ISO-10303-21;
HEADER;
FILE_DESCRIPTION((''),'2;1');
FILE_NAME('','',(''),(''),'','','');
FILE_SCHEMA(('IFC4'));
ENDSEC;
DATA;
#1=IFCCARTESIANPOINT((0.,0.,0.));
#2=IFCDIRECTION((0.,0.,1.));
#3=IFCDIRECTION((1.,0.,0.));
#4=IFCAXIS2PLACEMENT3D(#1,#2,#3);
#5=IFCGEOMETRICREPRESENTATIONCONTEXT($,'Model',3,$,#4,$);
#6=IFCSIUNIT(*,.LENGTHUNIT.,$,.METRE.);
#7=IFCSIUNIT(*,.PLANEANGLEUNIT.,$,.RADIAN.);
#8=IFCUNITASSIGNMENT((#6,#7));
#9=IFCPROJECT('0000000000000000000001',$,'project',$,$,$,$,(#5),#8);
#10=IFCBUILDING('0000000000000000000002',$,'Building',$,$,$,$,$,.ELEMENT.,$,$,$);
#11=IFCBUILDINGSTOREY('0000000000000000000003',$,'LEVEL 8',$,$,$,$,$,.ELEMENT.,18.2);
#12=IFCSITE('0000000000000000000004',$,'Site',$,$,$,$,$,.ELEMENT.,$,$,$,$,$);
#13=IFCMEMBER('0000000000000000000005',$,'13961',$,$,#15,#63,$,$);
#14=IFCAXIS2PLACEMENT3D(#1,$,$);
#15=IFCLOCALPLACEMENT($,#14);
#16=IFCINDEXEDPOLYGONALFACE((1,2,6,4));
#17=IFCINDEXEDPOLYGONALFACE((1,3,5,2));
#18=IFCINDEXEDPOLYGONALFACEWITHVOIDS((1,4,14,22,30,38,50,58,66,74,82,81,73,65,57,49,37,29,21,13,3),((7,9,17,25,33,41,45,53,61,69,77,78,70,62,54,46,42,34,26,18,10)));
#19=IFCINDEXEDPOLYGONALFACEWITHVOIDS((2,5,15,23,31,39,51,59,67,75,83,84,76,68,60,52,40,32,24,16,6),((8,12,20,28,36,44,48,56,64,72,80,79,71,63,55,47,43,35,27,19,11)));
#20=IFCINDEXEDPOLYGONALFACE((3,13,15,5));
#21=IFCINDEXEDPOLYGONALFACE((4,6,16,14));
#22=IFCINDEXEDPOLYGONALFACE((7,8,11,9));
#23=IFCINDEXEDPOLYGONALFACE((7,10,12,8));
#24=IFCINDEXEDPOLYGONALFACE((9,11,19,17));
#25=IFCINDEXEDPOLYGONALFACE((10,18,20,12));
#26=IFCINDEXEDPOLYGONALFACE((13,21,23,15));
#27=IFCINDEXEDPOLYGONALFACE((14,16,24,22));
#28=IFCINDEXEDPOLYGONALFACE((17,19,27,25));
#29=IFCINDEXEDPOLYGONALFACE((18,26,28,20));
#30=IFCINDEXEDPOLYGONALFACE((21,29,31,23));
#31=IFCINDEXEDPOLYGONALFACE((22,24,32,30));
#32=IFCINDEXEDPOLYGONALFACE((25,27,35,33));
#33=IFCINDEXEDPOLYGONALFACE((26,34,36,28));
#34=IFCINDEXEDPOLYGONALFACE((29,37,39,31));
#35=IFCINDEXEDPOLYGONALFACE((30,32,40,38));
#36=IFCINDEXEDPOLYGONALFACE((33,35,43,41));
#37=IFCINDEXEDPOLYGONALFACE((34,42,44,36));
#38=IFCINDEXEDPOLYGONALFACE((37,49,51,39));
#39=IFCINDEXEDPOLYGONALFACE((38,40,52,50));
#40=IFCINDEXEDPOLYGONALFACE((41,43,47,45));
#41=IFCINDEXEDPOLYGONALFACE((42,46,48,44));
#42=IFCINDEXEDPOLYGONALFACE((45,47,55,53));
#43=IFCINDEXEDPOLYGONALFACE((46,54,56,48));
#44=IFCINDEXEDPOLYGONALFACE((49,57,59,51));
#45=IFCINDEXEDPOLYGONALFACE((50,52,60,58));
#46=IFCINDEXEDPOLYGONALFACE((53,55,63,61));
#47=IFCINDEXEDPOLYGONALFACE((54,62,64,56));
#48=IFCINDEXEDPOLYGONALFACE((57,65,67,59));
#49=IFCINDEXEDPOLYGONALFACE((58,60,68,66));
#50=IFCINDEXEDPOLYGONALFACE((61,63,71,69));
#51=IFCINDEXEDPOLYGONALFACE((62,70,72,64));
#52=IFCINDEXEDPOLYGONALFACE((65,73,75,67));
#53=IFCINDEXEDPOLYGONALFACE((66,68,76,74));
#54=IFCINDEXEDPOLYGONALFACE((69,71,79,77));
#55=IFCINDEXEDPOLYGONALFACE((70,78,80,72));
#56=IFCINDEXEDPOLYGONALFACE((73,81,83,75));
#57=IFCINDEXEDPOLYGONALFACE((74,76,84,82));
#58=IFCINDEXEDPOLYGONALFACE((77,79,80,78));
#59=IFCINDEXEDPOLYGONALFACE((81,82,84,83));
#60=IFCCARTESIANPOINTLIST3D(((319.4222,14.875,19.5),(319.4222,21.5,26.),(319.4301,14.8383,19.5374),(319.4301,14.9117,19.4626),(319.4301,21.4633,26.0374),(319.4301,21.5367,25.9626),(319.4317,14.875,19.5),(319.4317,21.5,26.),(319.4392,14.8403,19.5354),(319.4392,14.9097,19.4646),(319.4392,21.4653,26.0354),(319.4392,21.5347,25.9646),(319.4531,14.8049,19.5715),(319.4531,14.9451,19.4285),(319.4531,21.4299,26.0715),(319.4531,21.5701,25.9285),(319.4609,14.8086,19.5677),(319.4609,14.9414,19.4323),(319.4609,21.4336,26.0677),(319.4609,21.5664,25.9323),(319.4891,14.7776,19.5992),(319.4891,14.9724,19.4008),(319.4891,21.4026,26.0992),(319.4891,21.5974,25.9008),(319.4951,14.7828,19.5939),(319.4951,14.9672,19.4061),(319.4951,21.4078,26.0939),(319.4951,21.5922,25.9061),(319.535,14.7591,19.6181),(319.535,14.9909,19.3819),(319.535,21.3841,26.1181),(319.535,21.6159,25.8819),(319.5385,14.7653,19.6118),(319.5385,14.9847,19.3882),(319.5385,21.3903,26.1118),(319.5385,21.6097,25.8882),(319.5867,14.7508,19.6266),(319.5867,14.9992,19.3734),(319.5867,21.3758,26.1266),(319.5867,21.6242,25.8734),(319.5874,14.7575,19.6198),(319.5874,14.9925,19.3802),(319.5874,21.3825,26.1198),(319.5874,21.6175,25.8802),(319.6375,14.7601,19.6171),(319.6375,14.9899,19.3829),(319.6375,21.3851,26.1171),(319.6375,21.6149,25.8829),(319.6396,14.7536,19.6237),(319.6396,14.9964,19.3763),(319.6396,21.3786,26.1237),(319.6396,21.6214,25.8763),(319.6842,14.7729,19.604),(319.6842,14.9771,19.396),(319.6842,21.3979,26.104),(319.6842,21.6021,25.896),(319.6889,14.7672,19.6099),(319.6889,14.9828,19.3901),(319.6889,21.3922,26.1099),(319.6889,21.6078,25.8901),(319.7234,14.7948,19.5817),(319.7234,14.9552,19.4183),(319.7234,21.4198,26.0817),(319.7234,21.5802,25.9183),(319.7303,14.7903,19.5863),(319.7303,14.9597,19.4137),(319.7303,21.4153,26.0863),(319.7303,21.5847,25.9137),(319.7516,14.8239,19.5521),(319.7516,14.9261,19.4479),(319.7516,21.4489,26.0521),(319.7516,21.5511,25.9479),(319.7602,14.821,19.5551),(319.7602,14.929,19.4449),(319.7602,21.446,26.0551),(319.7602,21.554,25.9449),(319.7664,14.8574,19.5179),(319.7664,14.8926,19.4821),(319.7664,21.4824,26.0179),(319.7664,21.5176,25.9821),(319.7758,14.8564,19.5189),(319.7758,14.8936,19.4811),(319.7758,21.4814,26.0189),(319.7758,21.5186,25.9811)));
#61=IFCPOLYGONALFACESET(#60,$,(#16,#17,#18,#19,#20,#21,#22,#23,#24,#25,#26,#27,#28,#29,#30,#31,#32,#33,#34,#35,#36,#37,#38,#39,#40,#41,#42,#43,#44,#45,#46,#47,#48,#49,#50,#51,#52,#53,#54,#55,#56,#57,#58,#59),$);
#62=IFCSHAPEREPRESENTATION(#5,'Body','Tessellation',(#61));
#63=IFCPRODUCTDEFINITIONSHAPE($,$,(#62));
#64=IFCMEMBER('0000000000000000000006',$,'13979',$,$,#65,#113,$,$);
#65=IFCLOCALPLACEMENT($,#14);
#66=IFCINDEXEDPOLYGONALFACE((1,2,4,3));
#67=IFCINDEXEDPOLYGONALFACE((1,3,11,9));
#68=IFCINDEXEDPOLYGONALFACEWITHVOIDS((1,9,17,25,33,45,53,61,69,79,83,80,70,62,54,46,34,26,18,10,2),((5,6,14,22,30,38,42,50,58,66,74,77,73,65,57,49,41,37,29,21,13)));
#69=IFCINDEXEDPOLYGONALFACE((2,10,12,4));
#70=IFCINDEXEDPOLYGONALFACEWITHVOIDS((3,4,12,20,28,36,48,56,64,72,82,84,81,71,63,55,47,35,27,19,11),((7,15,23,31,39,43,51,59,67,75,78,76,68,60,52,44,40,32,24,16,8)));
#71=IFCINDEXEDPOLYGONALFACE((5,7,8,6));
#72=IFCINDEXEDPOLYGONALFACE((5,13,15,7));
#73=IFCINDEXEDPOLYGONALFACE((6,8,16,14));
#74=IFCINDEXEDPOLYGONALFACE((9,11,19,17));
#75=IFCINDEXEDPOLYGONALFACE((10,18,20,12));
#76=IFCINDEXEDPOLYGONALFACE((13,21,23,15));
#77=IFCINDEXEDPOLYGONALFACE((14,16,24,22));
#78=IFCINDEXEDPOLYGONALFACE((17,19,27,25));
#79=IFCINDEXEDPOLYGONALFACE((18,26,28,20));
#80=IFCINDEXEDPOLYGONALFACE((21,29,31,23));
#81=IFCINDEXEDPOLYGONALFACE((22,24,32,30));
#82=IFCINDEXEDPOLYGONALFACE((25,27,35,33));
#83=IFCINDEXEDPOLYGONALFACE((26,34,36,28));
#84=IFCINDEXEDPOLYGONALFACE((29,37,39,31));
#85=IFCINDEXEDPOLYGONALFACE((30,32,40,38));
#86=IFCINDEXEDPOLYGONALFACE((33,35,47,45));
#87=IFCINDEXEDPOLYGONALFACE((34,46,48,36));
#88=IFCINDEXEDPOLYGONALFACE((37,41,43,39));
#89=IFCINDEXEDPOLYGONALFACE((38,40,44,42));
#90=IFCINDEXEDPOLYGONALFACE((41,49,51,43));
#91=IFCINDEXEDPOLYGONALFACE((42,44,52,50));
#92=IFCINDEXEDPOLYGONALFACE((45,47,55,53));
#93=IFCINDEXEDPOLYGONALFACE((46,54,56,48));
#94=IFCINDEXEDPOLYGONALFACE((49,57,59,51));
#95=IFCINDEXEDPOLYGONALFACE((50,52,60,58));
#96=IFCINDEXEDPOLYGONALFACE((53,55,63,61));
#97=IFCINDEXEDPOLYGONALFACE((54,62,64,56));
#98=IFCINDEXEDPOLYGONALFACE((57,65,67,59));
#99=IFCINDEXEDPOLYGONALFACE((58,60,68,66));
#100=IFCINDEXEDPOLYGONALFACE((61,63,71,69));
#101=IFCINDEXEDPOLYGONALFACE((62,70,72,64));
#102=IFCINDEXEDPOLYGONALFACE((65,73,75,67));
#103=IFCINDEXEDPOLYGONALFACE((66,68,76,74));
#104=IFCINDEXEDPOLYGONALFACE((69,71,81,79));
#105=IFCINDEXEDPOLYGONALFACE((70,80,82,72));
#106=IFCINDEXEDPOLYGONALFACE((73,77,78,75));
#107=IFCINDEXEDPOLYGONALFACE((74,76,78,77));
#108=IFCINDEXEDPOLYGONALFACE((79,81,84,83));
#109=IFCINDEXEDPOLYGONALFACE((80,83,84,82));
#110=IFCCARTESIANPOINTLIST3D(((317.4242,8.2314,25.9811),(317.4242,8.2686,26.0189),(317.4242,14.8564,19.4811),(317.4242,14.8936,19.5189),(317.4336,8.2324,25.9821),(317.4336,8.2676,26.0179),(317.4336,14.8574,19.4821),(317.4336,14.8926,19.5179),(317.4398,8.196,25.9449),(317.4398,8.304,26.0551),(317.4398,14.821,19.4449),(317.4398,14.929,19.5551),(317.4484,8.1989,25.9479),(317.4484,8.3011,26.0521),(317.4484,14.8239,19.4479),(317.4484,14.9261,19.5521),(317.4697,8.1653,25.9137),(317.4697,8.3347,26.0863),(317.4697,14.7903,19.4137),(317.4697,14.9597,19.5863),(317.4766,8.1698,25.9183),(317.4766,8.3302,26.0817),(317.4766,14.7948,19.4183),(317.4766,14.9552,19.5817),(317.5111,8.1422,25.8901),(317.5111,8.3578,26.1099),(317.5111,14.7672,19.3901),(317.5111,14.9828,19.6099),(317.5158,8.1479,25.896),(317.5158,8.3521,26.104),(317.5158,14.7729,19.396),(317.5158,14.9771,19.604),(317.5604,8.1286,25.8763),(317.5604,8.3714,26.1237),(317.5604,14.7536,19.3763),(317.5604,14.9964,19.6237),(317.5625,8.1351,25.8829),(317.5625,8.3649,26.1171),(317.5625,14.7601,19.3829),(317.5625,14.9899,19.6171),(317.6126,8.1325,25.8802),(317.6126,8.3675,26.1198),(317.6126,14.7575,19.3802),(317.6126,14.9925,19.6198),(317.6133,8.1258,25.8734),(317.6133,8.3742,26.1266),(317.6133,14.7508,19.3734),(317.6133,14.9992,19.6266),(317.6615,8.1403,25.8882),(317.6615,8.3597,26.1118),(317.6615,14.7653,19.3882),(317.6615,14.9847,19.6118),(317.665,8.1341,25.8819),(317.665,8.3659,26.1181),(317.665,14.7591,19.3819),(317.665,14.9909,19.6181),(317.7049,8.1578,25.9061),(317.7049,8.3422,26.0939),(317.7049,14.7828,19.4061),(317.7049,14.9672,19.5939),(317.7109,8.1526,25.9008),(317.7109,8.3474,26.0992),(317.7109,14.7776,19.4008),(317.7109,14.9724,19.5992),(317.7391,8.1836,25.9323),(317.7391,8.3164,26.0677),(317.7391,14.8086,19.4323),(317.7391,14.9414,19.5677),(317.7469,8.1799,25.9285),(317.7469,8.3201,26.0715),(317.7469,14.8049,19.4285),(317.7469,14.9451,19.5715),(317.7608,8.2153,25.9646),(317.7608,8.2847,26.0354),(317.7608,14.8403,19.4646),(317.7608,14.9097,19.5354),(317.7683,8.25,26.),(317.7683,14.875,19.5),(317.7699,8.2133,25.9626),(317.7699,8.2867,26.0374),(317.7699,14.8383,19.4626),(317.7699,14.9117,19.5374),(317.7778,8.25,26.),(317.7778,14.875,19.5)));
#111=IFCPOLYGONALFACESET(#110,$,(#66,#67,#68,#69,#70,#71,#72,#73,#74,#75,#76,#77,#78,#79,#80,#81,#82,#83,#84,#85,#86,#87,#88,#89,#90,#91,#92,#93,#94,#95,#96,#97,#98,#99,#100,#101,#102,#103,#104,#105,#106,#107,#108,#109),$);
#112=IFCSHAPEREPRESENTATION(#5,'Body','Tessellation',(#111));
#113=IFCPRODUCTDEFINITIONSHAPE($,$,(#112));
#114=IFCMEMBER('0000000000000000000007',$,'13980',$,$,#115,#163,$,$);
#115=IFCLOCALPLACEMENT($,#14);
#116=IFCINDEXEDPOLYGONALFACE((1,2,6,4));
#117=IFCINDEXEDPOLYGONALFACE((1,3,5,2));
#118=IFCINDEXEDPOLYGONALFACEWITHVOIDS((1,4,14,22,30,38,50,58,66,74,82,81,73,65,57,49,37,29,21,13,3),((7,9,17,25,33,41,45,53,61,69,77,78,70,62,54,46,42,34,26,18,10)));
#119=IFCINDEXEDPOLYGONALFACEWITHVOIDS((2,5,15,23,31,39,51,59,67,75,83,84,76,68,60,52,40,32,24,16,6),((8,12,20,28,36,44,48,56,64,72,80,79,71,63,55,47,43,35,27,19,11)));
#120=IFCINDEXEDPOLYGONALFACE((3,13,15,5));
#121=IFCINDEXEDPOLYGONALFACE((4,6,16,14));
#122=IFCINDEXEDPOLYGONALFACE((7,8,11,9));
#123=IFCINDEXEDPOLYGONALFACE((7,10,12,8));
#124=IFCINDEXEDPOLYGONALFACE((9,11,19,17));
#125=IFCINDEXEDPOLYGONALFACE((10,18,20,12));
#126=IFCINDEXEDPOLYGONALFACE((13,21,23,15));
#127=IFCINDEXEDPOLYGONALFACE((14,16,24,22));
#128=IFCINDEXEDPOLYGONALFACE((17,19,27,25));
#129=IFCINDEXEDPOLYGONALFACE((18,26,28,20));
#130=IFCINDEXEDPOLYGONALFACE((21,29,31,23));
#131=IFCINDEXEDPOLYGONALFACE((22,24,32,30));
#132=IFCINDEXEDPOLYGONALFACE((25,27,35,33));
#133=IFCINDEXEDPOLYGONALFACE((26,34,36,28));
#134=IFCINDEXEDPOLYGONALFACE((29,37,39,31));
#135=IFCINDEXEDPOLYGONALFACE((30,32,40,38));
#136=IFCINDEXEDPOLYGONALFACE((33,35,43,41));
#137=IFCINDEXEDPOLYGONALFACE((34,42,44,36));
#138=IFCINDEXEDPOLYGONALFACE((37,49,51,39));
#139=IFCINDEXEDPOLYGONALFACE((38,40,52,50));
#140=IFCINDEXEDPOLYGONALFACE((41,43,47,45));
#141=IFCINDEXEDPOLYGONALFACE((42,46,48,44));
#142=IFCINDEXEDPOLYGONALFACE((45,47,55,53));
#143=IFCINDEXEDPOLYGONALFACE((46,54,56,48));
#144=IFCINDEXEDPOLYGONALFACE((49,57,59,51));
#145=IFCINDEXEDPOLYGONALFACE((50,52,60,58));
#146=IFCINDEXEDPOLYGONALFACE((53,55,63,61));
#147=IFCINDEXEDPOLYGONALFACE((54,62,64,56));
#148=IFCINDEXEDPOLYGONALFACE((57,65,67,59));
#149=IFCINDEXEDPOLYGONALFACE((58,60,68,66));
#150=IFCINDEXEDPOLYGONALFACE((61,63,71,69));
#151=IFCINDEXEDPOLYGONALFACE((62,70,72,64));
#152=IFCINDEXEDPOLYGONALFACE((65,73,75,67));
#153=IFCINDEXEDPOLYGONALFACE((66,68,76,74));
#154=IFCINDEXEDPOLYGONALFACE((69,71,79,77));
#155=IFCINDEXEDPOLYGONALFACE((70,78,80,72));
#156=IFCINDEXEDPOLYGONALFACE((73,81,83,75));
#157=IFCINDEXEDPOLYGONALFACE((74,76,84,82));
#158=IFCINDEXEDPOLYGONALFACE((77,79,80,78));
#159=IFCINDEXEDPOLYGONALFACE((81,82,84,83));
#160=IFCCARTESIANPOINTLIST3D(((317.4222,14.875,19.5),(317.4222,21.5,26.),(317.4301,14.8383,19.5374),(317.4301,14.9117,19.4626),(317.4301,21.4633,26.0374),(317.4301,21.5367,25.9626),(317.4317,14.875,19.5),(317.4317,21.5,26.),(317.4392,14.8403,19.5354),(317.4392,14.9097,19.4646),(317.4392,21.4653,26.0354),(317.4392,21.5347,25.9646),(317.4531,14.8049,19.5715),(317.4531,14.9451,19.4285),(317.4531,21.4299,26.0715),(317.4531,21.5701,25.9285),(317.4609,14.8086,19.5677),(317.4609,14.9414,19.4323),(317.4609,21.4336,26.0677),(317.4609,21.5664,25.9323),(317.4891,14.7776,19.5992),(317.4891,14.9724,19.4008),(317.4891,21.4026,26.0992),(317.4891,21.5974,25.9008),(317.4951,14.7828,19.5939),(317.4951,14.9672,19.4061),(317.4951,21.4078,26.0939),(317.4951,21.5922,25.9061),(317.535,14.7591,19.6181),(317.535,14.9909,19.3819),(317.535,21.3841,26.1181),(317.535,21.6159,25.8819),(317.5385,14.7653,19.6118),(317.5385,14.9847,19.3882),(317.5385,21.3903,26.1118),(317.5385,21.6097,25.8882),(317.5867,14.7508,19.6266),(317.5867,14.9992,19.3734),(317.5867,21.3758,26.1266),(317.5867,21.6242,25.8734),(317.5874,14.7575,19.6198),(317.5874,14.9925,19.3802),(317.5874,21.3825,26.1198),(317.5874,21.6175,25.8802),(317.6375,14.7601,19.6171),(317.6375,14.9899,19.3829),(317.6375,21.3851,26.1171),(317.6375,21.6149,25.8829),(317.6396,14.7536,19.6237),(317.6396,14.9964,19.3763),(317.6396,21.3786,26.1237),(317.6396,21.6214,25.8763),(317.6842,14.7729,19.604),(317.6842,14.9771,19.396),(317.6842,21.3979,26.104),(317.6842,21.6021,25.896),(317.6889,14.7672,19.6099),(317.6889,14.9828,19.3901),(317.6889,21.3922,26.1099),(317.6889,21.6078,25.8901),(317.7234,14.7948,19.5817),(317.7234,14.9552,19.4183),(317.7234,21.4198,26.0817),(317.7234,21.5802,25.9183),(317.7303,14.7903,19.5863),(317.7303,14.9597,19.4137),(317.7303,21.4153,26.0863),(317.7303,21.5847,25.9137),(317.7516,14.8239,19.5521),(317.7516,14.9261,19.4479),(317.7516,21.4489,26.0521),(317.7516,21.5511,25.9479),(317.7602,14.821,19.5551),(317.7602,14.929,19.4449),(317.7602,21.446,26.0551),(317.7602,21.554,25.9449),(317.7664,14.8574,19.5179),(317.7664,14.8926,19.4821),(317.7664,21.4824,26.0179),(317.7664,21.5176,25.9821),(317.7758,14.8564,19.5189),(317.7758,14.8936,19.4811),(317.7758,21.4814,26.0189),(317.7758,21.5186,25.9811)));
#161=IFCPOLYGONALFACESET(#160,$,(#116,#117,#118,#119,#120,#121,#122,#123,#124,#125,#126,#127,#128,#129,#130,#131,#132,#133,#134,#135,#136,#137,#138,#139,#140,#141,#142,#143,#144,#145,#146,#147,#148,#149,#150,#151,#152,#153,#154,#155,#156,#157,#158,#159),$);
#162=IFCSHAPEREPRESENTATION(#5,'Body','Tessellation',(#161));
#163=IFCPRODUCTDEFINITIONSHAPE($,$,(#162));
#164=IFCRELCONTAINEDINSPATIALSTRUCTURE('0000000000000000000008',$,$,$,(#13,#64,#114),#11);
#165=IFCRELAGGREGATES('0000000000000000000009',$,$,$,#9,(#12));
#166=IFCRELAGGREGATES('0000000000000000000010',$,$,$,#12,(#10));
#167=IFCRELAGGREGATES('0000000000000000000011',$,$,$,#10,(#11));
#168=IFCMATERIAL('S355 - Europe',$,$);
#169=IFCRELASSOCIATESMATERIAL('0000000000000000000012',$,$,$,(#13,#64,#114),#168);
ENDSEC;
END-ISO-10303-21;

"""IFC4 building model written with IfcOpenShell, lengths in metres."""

from ifc_helpers import new_model, si_unit, frame, origin_with_axes, origin_2d_with_axis, place, context, project, spatial, hollow_circle, extrude, material, material_profile, profile_set, profile_usage, element, save


model = new_model("IFC4")

# Units and contexts
model_context = context("Model", 3, world=origin_with_axes())
ifc_project = project(units=[si_unit("LENGTHUNIT", "METRE"), si_unit("PLANEANGLEUNIT", "RADIAN")], contexts=[model_context])

# Site, building, storey
site = spatial("IfcSite", under=ifc_project, Name="Site", CompositionType="ELEMENT")
building = spatial("IfcBuilding", under=site, Name="Building", CompositionType="ELEMENT")
storey = spatial("IfcBuildingStorey", under=building, Name="LEVEL 8", CompositionType="ELEMENT", Elevation=18.2)

# Shared definitions
ifc_material = material(Name="S355 - Europe")

# Members
ifc_material_profile_1 = material_profile(ifc_material, hollow_circle(Radius=0.1778, WallThickness=0.0095, at=origin_2d_with_axis()))
ifc_profile_set_1 = profile_set([ifc_material_profile_1])
ifc_profile_usage_1 = profile_usage(ifc_profile_set_1, cardinal=10)
member_1_placement = place(None, frame((319.6, 14.875, 19.5), z_axis=(0.0, 0.713809, 0.700341), x_axis=(-1.0, 0.0, 0.0)))
element("IfcMember", 1, at=member_1_placement, inside=storey, material=ifc_profile_usage_1, Name="13961", context=model_context, shape_type="SweptSolid", body=[
    extrude(hollow_circle(Radius=0.1778, WallThickness=0.0095, at=origin_2d_with_axis()), origin_with_axes(), (0.0, 0.0, 1.0), 9.2812),
])
ifc_material_profile_2 = material_profile(ifc_material, hollow_circle(Radius=0.1778, WallThickness=0.0095, at=origin_2d_with_axis()))
ifc_profile_set_2 = profile_set([ifc_material_profile_2])
ifc_profile_usage_2 = profile_usage(ifc_profile_set_2, cardinal=10)
member_2_placement = place(None, frame((317.6, 14.875, 19.5), z_axis=(0.0, -0.713809, 0.700341), x_axis=(1.0, 0.0, 0.0)))
element("IfcMember", 2, at=member_2_placement, inside=storey, material=ifc_profile_usage_2, Name="13979", context=model_context, shape_type="SweptSolid", body=[
    extrude(hollow_circle(Radius=0.1778, WallThickness=0.0095, at=origin_2d_with_axis()), origin_with_axes(), (0.0, 0.0, 1.0), 9.2812),
])
ifc_material_profile_3 = material_profile(ifc_material, hollow_circle(Radius=0.1778, WallThickness=0.0095, at=origin_2d_with_axis()))
ifc_profile_set_3 = profile_set([ifc_material_profile_3])
ifc_profile_usage_3 = profile_usage(ifc_profile_set_3, cardinal=10)
member_3_placement = place(None, frame((317.6, 14.875, 19.5), z_axis=(0.0, 0.713809, 0.700341), x_axis=(-1.0, 0.0, 0.0)))
element("IfcMember", 3, at=member_3_placement, inside=storey, material=ifc_profile_usage_3, Name="13980", context=model_context, shape_type="SweptSolid", body=[
    extrude(hollow_circle(Radius=0.1778, WallThickness=0.0095, at=origin_2d_with_axis()), origin_with_axes(), (0.0, 0.0, 1.0), 9.2812),
])

save(model, "model.ifc")
